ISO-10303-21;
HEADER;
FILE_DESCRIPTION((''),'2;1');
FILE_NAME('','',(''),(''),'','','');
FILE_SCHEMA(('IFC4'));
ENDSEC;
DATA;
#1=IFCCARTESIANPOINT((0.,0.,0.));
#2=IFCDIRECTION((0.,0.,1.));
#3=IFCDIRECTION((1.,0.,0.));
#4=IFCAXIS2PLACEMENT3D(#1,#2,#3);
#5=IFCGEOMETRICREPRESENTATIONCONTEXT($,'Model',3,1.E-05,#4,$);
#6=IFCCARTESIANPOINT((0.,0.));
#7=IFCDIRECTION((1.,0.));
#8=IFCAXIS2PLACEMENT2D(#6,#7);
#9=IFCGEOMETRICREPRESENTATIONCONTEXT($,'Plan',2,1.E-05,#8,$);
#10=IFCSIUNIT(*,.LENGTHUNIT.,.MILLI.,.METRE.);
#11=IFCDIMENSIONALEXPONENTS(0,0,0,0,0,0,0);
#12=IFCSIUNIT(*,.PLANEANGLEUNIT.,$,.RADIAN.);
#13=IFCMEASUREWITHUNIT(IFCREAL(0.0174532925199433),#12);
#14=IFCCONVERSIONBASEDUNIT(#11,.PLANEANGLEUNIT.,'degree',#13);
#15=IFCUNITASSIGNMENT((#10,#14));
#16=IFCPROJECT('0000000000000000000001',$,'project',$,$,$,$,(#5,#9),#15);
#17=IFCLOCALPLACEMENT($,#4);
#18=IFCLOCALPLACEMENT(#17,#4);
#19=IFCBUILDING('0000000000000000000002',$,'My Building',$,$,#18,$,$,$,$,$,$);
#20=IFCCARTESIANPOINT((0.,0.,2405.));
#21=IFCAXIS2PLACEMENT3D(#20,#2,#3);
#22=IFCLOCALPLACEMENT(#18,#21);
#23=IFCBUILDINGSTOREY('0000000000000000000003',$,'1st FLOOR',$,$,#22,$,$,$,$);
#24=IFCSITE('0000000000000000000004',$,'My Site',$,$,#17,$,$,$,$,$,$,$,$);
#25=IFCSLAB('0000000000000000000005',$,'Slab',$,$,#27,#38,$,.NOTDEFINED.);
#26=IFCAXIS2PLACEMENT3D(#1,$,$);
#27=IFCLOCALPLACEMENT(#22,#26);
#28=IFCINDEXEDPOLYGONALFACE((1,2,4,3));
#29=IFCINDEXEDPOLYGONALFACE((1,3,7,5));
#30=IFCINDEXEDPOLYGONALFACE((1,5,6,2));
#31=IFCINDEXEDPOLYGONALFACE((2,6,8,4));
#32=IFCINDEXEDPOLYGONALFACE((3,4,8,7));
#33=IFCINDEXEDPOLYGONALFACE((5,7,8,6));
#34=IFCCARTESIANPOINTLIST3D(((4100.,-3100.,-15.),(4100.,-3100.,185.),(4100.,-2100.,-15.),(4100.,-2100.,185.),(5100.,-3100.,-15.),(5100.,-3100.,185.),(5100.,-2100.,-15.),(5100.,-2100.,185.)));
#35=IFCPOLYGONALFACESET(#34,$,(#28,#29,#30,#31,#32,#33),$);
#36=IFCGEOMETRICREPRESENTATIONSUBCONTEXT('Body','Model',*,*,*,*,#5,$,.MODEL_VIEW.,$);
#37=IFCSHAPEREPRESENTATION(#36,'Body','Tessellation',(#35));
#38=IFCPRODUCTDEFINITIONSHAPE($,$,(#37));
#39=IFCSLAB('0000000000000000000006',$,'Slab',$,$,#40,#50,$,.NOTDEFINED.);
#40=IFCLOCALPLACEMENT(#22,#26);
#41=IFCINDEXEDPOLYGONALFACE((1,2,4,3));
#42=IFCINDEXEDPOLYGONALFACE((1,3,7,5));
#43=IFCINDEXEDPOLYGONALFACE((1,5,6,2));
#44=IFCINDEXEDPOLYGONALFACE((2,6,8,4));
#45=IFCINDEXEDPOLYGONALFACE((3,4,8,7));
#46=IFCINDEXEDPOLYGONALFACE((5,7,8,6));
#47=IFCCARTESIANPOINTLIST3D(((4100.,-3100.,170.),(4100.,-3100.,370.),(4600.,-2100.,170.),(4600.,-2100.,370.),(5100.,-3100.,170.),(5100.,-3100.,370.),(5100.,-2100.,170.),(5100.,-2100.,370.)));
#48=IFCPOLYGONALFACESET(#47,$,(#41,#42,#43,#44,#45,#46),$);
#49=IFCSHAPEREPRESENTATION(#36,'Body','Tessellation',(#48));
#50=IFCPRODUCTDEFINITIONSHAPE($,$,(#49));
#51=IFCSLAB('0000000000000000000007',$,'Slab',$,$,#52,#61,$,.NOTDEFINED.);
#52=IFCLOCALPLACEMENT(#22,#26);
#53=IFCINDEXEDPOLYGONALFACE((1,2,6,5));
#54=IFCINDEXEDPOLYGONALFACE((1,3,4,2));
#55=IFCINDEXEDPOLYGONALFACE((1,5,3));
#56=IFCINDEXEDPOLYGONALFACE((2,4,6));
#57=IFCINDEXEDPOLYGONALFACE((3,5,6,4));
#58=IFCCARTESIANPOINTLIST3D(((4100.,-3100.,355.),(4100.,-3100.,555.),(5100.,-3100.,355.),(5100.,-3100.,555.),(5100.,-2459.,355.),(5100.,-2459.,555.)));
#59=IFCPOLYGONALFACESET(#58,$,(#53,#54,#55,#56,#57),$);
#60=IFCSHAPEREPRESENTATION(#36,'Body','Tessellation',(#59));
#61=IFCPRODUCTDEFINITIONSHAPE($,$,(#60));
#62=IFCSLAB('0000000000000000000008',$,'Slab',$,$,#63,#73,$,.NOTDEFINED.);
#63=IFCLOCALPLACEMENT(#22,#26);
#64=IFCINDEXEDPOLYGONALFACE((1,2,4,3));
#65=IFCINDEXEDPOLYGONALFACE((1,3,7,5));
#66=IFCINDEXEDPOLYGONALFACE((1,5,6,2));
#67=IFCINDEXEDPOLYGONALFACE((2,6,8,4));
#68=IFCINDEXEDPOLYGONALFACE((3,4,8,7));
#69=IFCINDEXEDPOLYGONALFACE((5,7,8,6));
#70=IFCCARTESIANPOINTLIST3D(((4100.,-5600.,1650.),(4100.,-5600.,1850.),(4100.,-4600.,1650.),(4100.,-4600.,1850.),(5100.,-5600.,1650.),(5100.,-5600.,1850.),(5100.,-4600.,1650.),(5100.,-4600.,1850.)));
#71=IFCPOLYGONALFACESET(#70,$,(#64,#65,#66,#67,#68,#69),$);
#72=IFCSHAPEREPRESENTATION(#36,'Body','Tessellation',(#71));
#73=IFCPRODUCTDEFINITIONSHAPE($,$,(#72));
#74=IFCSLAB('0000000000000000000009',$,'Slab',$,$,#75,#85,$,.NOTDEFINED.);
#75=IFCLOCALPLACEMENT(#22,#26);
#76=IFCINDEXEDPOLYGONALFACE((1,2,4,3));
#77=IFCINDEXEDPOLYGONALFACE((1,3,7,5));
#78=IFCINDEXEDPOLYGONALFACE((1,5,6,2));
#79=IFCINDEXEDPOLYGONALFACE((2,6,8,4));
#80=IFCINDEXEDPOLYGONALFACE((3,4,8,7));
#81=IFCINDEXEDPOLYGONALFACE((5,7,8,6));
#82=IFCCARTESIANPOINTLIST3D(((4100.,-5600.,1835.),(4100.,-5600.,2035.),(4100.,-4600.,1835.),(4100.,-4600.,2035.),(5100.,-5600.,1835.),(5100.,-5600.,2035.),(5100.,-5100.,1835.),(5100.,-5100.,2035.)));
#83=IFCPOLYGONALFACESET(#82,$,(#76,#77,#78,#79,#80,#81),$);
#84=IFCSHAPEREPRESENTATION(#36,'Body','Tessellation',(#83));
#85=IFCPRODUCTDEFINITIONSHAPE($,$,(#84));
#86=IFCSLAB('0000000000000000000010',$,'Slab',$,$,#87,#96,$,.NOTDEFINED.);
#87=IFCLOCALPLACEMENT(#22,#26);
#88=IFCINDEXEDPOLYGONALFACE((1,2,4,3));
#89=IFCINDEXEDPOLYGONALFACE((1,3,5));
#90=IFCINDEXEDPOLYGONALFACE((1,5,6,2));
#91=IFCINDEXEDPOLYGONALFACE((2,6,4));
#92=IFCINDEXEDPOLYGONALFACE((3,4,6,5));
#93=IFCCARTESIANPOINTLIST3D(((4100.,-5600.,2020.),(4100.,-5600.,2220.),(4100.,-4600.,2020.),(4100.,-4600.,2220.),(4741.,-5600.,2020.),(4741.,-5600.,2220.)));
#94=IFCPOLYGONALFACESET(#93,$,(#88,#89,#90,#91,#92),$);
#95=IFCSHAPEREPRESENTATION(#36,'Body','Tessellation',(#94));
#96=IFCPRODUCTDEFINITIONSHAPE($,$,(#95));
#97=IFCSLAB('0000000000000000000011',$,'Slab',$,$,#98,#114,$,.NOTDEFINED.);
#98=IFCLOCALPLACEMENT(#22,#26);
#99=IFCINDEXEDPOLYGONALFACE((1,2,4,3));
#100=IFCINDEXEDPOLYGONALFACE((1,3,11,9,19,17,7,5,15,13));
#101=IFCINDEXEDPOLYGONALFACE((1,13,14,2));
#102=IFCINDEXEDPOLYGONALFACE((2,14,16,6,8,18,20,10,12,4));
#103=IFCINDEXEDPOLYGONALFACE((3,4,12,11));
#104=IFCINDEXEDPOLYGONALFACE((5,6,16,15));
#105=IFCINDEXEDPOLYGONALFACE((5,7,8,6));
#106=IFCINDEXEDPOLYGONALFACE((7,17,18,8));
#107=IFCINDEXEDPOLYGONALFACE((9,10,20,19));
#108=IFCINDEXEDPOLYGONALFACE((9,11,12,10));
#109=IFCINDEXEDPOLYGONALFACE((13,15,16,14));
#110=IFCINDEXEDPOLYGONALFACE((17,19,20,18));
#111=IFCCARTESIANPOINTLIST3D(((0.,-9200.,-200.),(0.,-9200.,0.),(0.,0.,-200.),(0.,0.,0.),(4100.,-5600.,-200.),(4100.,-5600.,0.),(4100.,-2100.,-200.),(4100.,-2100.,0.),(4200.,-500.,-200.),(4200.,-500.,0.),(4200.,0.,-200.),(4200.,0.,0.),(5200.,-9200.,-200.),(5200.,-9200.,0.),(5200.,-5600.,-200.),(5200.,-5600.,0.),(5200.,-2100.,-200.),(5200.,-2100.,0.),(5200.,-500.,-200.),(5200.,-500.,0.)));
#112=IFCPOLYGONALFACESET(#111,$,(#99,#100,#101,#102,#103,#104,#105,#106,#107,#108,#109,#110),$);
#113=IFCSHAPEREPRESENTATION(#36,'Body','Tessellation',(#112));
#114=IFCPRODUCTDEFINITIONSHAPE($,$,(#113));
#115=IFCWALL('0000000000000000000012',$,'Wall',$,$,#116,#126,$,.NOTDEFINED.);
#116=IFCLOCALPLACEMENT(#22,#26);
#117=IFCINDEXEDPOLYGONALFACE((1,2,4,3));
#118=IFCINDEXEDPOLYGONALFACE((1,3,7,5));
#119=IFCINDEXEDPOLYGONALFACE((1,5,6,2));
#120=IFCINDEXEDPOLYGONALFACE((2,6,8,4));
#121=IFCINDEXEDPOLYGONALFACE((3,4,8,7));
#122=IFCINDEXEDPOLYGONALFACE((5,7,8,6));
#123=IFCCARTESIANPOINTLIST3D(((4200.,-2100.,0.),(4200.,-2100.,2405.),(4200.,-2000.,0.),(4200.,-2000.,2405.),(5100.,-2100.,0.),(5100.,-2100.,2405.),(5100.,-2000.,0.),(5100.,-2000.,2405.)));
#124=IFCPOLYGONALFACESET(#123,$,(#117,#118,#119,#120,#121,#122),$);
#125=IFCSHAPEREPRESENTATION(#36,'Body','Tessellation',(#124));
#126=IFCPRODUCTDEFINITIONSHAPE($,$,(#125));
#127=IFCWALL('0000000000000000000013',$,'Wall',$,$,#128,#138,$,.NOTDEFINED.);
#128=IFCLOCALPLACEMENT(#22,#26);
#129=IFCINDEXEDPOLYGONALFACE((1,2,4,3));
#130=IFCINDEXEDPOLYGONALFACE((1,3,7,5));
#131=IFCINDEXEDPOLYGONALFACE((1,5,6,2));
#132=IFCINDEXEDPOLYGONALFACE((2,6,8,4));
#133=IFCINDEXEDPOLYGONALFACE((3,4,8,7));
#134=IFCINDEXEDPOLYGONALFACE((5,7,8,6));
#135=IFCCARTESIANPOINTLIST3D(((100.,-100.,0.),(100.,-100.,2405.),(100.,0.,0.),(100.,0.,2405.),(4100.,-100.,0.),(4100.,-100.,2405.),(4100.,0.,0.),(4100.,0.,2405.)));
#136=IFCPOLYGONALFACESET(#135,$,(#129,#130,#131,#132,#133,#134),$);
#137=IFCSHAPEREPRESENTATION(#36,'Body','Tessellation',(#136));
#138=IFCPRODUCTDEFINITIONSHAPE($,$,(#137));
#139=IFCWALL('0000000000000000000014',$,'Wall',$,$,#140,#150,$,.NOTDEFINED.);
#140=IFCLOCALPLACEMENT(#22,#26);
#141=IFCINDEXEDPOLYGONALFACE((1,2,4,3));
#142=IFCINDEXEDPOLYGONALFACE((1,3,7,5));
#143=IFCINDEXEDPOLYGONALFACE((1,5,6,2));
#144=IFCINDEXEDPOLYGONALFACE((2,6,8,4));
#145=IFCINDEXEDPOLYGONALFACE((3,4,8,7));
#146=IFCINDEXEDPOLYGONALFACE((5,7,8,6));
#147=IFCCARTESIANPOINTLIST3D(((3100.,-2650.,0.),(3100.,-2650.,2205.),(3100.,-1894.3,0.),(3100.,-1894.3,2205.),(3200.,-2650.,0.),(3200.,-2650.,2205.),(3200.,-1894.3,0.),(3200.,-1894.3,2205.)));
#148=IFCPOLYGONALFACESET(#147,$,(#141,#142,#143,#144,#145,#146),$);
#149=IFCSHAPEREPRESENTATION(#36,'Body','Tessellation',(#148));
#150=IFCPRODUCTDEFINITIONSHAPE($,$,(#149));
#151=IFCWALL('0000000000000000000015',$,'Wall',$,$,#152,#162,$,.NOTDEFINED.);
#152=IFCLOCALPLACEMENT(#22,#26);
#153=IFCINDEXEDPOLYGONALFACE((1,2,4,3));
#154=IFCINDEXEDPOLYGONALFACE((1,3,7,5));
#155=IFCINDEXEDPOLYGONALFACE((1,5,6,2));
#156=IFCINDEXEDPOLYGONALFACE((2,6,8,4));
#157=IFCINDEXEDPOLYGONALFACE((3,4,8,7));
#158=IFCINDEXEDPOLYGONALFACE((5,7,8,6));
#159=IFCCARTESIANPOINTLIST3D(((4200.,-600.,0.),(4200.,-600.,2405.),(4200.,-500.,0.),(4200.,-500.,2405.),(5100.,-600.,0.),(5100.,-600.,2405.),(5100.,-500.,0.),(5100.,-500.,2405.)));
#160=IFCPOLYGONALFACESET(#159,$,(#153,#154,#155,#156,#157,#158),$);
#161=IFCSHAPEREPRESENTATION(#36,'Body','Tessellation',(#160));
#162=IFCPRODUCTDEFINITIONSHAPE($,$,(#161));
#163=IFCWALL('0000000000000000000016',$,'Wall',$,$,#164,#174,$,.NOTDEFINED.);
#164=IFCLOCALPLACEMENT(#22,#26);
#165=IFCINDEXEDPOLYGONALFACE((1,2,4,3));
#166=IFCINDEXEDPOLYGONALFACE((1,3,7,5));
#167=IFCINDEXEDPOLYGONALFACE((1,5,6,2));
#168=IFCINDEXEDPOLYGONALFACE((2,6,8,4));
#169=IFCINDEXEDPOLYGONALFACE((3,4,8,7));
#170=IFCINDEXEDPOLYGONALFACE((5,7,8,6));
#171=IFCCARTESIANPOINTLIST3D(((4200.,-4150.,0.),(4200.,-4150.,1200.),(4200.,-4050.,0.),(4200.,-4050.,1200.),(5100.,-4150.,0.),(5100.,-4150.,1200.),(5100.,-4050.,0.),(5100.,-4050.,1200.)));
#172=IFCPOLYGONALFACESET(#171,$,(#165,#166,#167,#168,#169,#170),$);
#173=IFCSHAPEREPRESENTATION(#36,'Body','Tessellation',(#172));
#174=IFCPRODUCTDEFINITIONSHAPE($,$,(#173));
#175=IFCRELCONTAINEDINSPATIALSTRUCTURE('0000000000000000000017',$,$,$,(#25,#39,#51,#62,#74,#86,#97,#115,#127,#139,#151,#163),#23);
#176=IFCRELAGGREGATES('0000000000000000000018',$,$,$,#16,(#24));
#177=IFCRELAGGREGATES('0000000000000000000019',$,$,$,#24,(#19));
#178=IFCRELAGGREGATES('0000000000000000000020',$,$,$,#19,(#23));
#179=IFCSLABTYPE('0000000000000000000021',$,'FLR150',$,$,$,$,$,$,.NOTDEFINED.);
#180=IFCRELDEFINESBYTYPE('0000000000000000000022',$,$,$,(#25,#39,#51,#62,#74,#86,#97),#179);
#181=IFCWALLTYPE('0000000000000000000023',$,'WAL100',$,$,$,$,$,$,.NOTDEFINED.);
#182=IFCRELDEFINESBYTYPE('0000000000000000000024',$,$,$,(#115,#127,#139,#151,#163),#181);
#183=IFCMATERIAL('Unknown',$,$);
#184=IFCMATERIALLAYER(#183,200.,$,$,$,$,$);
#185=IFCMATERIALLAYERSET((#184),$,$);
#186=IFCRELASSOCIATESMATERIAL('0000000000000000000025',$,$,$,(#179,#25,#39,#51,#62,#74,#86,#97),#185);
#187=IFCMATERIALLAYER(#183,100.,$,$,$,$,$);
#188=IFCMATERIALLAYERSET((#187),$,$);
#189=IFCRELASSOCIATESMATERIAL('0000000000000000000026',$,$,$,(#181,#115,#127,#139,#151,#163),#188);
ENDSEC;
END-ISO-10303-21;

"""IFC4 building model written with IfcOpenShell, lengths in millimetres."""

from ifc_helpers import new_model, entity, si_unit, converted_unit, frame, origin_with_axes, origin_2d_with_axis, place, context, subcontext, project, spatial, line, indexed_curve, outline, extrude, material, layer, layer_set, layer_usage, type_object, element, save


model = new_model("IFC4")

# Units and contexts
model_context = context("Model", 3, precision=1e-05, world=origin_with_axes())
plan_context = context("Plan", 2, precision=1e-05, world=origin_2d_with_axis())
body_context = subcontext(model_context, "Body", "Model", "MODEL_VIEW")
ifc_project = project(units=[si_unit("LENGTHUNIT", "METRE", prefix="MILLI"), converted_unit("PLANEANGLEUNIT", "degree", entity("IfcReal", 0.0174532925199433), si_unit("PLANEANGLEUNIT", "RADIAN"), dimensions=[0, 0, 0, 0, 0, 0, 0])], contexts=[model_context, plan_context])

# Site, building, storey
site_placement = place(None, origin_with_axes())
site = spatial("IfcSite", under=ifc_project, at=site_placement, Name="My Site")
building_placement = place(site_placement, origin_with_axes())
building = spatial("IfcBuilding", under=site, at=building_placement, Name="My Building")
storey_placement = place(building_placement, frame((0.0, 0.0, 2405.0), z_axis=(0.0, 0.0, 1.0), x_axis=(1.0, 0.0, 0.0)))
storey = spatial("IfcBuildingStorey", under=building, at=storey_placement, Name="1st FLOOR")

# Slabs
ifc_material = material(Name="Unknown")
ifc_layer_1 = layer(ifc_material, 200.0)
ifc_layer_set_1 = layer_set([ifc_layer_1])
ifc_layer_usage_1 = layer_usage(ifc_layer_set_1, "AXIS3", "POSITIVE", 0.0)
slab_type = type_object("IfcSlabType", Name="FLR150", PredefinedType="NOTDEFINED", material=ifc_layer_set_1)
slab_1_placement = place(storey_placement, frame((4100.0, -3100.0, -15.0), z_axis=(0.0, 0.0, 1.0), x_axis=(1.0, 0.0, 0.0)))
element("IfcSlab", 1, at=slab_1_placement, inside=storey, type_object=slab_type, material=ifc_layer_usage_1, Name="Slab", PredefinedType="NOTDEFINED", context=body_context, shape_type="SweptSolid", body=[
    extrude(outline(indexed_curve([(0.0, 0.0), (1000.0, 0.0), (1000.0, 1000.0), (0.0, 1000.0), (0.0, 0.0)])), None, (0.0, 0.0, 1.0), 200.0),
])
ifc_layer_usage_2 = layer_usage(ifc_layer_set_1, "AXIS3", "POSITIVE", 0.0)
slab_2_placement = place(storey_placement, frame((4100.0, -3100.0, 170.0), z_axis=(0.0, 0.0, 1.0), x_axis=(1.0, 0.0, 0.0)))
element("IfcSlab", 2, at=slab_2_placement, inside=storey, type_object=slab_type, material=ifc_layer_usage_2, Name="Slab", PredefinedType="NOTDEFINED", context=body_context, shape_type="SweptSolid", body=[
    extrude(outline(indexed_curve([(0.0, 0.0), (1000.0, 0.0), (1000.0, 1000.0), (500.0, 1000.0)], segments=[line(4, 1), line(1, 2), line(2, 3), line(3, 4)], self_intersect=False)), None, (0.0, 0.0, 1.0), 200.0),
])
ifc_layer_usage_3 = layer_usage(ifc_layer_set_1, "AXIS3", "POSITIVE", 0.0)
slab_3_placement = place(storey_placement, frame((4100.0, -3100.0, 355.0), z_axis=(0.0, 0.0, 1.0), x_axis=(1.0, 0.0, 0.0)))
element("IfcSlab", 3, at=slab_3_placement, inside=storey, type_object=slab_type, material=ifc_layer_usage_3, Name="Slab", PredefinedType="NOTDEFINED", context=body_context, shape_type="SweptSolid", body=[
    extrude(outline(indexed_curve([(0.0, 0.0), (1000.0, 0.0), (1000.0, 641.0)], segments=[line(2, 3), line(3, 1), line(1, 2)], self_intersect=False)), None, (0.0, 0.0, 1.0), 200.0),
])
ifc_layer_usage_4 = layer_usage(ifc_layer_set_1, "AXIS3", "POSITIVE", 0.0)
slab_4_placement = place(storey_placement, frame((4100.0, -4600.0, 1650.0), z_axis=(0.0, 0.0, 1.0), x_axis=(0.0, -1.0, 0.0)))
element("IfcSlab", 4, at=slab_4_placement, inside=storey, type_object=slab_type, material=ifc_layer_usage_4, Name="Slab", PredefinedType="NOTDEFINED", context=body_context, shape_type="SweptSolid", body=[
    extrude(outline(indexed_curve([(0.0, 0.0), (1000.0, 0.0), (1000.0, 1000.0), (0.0, 1000.0), (0.0, 0.0)])), None, (0.0, 0.0, 1.0), 200.0),
])
ifc_layer_usage_5 = layer_usage(ifc_layer_set_1, "AXIS3", "POSITIVE", 0.0)
slab_5_placement = place(storey_placement, frame((4100.0, -4600.0, 1835.0), z_axis=(0.0, 0.0, 1.0), x_axis=(0.0, -1.0, 0.0)))
element("IfcSlab", 5, at=slab_5_placement, inside=storey, type_object=slab_type, material=ifc_layer_usage_5, Name="Slab", PredefinedType="NOTDEFINED", context=body_context, shape_type="SweptSolid", body=[
    extrude(outline(indexed_curve([(0.0, 0.0), (1000.0, 0.0), (1000.0, 1000.0), (500.0, 1000.0)], segments=[line(4, 1), line(1, 2), line(2, 3), line(3, 4)], self_intersect=False)), None, (0.0, 0.0, 1.0), 200.0),
])
ifc_layer_usage_6 = layer_usage(ifc_layer_set_1, "AXIS3", "POSITIVE", 0.0)
slab_6_placement = place(storey_placement, frame((4100.0, -4600.0, 2020.0), z_axis=(0.0, 0.0, 1.0), x_axis=(0.0, -1.0, 0.0)))
element("IfcSlab", 6, at=slab_6_placement, inside=storey, type_object=slab_type, material=ifc_layer_usage_6, Name="Slab", PredefinedType="NOTDEFINED", context=body_context, shape_type="SweptSolid", body=[
    extrude(outline(indexed_curve([(0.0, 0.0), (1000.0, 0.0), (1000.0, 641.0)], segments=[line(2, 3), line(3, 1), line(1, 2)], self_intersect=False)), None, (0.0, 0.0, 1.0), 200.0),
])
ifc_layer_usage_7 = layer_usage(ifc_layer_set_1, "AXIS3", "POSITIVE", 0.0)
slab_7_placement = place(storey_placement, frame((0.0, -9200.0, -200.0), z_axis=(0.0, 0.0, 1.0), x_axis=(1.0, 0.0, 0.0)))
element("IfcSlab", 7, at=slab_7_placement, inside=storey, type_object=slab_type, material=ifc_layer_usage_7, Name="Slab", PredefinedType="NOTDEFINED", context=body_context, shape_type="SweptSolid", body=[
    extrude(outline(indexed_curve([(4200.0, 8700.0), (5200.0, 0.0), (0.0, 0.0), (0.0, 9200.0), (4200.0, 9200.0), (5200.0, 8700.0), (5200.0, 3600.0), (5200.0, 7100.0), (4100.0, 3600.0), (4100.0, 7100.0)], segments=[line(10, 9), line(9, 7), line(7, 2), line(2, 3), line(3, 4), line(4, 5), line(5, 1), line(1, 6), line(6, 8), line(8, 10)], self_intersect=False)), None, (0.0, 0.0, 1.0), 200.0),
])

# Walls
ifc_layer_2 = layer(ifc_material, 100.0)
ifc_layer_set_2 = layer_set([ifc_layer_2])
ifc_layer_usage_8 = layer_usage(ifc_layer_set_2, "AXIS2", "POSITIVE", 0.0)
wall_type = type_object("IfcWallType", Name="WAL100", PredefinedType="NOTDEFINED", material=ifc_layer_set_2)
wall_1_placement = place(storey_placement, frame((5100.0, -2000.0, 0.0), z_axis=(0.0, 0.0, 1.0), x_axis=(-1.0, 0.0, 0.0)))
element("IfcWall", 8, at=wall_1_placement, inside=storey, type_object=wall_type, material=ifc_layer_usage_8, Name="Wall", PredefinedType="NOTDEFINED", context=body_context, shape_type="SweptSolid", body=[
    extrude(outline(indexed_curve([(0.0, 0.0), (0.0, 100.0), (900.0, 100.0), (900.0, 0.0), (0.0, 0.0)], self_intersect=False)), origin_with_axes(), (0.0, 0.0, 1.0), 2405.0),
])
ifc_layer_usage_9 = layer_usage(ifc_layer_set_2, "AXIS2", "POSITIVE", 0.0)
wall_2_placement = place(storey_placement, frame((4100.0, 0.0, 0.0), z_axis=(0.0, 0.0, 1.0), x_axis=(-1.0, 0.0, 0.0)))
element("IfcWall", 9, at=wall_2_placement, inside=storey, type_object=wall_type, material=ifc_layer_usage_9, Name="Wall", PredefinedType="NOTDEFINED", context=body_context, shape_type="SweptSolid", body=[
    extrude(outline(indexed_curve([(0.0, 0.0), (0.0, 100.0), (4000.0, 100.0), (4000.0, 0.0), (0.0, 0.0)], self_intersect=False)), origin_with_axes(), (0.0, 0.0, 1.0), 2405.0),
])
ifc_layer_usage_10 = layer_usage(ifc_layer_set_2, "AXIS2", "POSITIVE", 0.0)
wall_3_placement = place(storey_placement, frame((3200.0, -2650.0, 0.0), z_axis=(0.0, 0.0, 1.0), x_axis=(0.000001, 1.0, 0.0)))
element("IfcWall", 10, at=wall_3_placement, inside=storey, type_object=wall_type, material=ifc_layer_usage_10, Name="Wall", PredefinedType="NOTDEFINED", context=body_context, shape_type="SweptSolid", body=[
    extrude(outline(indexed_curve([(0.0, 0.0), (0.0, 100.0), (755.7, 100.0), (755.7, 0.0), (0.0, 0.0)], self_intersect=False)), origin_with_axes(), (0.0, 0.0, 1.0), 2205.0),
])
ifc_layer_usage_11 = layer_usage(ifc_layer_set_2, "AXIS2", "POSITIVE", 0.0)
wall_4_placement = place(storey_placement, frame((5100.0, -500.0, 0.0), z_axis=(0.0, 0.0, 1.0), x_axis=(-1.0, 0.0, 0.0)))
element("IfcWall", 11, at=wall_4_placement, inside=storey, type_object=wall_type, material=ifc_layer_usage_11, Name="Wall", PredefinedType="NOTDEFINED", context=body_context, shape_type="SweptSolid", body=[
    extrude(outline(indexed_curve([(0.0, 0.0), (0.0, 100.0), (900.0, 100.0), (900.0, 0.0), (0.0, 0.0)], self_intersect=False)), origin_with_axes(), (0.0, 0.0, 1.0), 2405.0),
])
ifc_layer_usage_12 = layer_usage(ifc_layer_set_2, "AXIS2", "POSITIVE", 0.0)
wall_5_placement = place(storey_placement, frame((5100.0, -4050.0, 0.0), z_axis=(0.0, 0.0, 1.0), x_axis=(-1.0, 0.0, 0.0)))
element("IfcWall", 12, at=wall_5_placement, inside=storey, type_object=wall_type, material=ifc_layer_usage_12, Name="Wall", PredefinedType="NOTDEFINED", context=body_context, shape_type="SweptSolid", body=[
    extrude(outline(indexed_curve([(0.0, 0.0), (0.0, 100.0), (900.0, 100.0), (900.0, 0.0), (0.0, 0.0)], self_intersect=False)), origin_with_axes(), (0.0, 0.0, 1.0), 1200.0),
])

save(model, "model.ifc")
